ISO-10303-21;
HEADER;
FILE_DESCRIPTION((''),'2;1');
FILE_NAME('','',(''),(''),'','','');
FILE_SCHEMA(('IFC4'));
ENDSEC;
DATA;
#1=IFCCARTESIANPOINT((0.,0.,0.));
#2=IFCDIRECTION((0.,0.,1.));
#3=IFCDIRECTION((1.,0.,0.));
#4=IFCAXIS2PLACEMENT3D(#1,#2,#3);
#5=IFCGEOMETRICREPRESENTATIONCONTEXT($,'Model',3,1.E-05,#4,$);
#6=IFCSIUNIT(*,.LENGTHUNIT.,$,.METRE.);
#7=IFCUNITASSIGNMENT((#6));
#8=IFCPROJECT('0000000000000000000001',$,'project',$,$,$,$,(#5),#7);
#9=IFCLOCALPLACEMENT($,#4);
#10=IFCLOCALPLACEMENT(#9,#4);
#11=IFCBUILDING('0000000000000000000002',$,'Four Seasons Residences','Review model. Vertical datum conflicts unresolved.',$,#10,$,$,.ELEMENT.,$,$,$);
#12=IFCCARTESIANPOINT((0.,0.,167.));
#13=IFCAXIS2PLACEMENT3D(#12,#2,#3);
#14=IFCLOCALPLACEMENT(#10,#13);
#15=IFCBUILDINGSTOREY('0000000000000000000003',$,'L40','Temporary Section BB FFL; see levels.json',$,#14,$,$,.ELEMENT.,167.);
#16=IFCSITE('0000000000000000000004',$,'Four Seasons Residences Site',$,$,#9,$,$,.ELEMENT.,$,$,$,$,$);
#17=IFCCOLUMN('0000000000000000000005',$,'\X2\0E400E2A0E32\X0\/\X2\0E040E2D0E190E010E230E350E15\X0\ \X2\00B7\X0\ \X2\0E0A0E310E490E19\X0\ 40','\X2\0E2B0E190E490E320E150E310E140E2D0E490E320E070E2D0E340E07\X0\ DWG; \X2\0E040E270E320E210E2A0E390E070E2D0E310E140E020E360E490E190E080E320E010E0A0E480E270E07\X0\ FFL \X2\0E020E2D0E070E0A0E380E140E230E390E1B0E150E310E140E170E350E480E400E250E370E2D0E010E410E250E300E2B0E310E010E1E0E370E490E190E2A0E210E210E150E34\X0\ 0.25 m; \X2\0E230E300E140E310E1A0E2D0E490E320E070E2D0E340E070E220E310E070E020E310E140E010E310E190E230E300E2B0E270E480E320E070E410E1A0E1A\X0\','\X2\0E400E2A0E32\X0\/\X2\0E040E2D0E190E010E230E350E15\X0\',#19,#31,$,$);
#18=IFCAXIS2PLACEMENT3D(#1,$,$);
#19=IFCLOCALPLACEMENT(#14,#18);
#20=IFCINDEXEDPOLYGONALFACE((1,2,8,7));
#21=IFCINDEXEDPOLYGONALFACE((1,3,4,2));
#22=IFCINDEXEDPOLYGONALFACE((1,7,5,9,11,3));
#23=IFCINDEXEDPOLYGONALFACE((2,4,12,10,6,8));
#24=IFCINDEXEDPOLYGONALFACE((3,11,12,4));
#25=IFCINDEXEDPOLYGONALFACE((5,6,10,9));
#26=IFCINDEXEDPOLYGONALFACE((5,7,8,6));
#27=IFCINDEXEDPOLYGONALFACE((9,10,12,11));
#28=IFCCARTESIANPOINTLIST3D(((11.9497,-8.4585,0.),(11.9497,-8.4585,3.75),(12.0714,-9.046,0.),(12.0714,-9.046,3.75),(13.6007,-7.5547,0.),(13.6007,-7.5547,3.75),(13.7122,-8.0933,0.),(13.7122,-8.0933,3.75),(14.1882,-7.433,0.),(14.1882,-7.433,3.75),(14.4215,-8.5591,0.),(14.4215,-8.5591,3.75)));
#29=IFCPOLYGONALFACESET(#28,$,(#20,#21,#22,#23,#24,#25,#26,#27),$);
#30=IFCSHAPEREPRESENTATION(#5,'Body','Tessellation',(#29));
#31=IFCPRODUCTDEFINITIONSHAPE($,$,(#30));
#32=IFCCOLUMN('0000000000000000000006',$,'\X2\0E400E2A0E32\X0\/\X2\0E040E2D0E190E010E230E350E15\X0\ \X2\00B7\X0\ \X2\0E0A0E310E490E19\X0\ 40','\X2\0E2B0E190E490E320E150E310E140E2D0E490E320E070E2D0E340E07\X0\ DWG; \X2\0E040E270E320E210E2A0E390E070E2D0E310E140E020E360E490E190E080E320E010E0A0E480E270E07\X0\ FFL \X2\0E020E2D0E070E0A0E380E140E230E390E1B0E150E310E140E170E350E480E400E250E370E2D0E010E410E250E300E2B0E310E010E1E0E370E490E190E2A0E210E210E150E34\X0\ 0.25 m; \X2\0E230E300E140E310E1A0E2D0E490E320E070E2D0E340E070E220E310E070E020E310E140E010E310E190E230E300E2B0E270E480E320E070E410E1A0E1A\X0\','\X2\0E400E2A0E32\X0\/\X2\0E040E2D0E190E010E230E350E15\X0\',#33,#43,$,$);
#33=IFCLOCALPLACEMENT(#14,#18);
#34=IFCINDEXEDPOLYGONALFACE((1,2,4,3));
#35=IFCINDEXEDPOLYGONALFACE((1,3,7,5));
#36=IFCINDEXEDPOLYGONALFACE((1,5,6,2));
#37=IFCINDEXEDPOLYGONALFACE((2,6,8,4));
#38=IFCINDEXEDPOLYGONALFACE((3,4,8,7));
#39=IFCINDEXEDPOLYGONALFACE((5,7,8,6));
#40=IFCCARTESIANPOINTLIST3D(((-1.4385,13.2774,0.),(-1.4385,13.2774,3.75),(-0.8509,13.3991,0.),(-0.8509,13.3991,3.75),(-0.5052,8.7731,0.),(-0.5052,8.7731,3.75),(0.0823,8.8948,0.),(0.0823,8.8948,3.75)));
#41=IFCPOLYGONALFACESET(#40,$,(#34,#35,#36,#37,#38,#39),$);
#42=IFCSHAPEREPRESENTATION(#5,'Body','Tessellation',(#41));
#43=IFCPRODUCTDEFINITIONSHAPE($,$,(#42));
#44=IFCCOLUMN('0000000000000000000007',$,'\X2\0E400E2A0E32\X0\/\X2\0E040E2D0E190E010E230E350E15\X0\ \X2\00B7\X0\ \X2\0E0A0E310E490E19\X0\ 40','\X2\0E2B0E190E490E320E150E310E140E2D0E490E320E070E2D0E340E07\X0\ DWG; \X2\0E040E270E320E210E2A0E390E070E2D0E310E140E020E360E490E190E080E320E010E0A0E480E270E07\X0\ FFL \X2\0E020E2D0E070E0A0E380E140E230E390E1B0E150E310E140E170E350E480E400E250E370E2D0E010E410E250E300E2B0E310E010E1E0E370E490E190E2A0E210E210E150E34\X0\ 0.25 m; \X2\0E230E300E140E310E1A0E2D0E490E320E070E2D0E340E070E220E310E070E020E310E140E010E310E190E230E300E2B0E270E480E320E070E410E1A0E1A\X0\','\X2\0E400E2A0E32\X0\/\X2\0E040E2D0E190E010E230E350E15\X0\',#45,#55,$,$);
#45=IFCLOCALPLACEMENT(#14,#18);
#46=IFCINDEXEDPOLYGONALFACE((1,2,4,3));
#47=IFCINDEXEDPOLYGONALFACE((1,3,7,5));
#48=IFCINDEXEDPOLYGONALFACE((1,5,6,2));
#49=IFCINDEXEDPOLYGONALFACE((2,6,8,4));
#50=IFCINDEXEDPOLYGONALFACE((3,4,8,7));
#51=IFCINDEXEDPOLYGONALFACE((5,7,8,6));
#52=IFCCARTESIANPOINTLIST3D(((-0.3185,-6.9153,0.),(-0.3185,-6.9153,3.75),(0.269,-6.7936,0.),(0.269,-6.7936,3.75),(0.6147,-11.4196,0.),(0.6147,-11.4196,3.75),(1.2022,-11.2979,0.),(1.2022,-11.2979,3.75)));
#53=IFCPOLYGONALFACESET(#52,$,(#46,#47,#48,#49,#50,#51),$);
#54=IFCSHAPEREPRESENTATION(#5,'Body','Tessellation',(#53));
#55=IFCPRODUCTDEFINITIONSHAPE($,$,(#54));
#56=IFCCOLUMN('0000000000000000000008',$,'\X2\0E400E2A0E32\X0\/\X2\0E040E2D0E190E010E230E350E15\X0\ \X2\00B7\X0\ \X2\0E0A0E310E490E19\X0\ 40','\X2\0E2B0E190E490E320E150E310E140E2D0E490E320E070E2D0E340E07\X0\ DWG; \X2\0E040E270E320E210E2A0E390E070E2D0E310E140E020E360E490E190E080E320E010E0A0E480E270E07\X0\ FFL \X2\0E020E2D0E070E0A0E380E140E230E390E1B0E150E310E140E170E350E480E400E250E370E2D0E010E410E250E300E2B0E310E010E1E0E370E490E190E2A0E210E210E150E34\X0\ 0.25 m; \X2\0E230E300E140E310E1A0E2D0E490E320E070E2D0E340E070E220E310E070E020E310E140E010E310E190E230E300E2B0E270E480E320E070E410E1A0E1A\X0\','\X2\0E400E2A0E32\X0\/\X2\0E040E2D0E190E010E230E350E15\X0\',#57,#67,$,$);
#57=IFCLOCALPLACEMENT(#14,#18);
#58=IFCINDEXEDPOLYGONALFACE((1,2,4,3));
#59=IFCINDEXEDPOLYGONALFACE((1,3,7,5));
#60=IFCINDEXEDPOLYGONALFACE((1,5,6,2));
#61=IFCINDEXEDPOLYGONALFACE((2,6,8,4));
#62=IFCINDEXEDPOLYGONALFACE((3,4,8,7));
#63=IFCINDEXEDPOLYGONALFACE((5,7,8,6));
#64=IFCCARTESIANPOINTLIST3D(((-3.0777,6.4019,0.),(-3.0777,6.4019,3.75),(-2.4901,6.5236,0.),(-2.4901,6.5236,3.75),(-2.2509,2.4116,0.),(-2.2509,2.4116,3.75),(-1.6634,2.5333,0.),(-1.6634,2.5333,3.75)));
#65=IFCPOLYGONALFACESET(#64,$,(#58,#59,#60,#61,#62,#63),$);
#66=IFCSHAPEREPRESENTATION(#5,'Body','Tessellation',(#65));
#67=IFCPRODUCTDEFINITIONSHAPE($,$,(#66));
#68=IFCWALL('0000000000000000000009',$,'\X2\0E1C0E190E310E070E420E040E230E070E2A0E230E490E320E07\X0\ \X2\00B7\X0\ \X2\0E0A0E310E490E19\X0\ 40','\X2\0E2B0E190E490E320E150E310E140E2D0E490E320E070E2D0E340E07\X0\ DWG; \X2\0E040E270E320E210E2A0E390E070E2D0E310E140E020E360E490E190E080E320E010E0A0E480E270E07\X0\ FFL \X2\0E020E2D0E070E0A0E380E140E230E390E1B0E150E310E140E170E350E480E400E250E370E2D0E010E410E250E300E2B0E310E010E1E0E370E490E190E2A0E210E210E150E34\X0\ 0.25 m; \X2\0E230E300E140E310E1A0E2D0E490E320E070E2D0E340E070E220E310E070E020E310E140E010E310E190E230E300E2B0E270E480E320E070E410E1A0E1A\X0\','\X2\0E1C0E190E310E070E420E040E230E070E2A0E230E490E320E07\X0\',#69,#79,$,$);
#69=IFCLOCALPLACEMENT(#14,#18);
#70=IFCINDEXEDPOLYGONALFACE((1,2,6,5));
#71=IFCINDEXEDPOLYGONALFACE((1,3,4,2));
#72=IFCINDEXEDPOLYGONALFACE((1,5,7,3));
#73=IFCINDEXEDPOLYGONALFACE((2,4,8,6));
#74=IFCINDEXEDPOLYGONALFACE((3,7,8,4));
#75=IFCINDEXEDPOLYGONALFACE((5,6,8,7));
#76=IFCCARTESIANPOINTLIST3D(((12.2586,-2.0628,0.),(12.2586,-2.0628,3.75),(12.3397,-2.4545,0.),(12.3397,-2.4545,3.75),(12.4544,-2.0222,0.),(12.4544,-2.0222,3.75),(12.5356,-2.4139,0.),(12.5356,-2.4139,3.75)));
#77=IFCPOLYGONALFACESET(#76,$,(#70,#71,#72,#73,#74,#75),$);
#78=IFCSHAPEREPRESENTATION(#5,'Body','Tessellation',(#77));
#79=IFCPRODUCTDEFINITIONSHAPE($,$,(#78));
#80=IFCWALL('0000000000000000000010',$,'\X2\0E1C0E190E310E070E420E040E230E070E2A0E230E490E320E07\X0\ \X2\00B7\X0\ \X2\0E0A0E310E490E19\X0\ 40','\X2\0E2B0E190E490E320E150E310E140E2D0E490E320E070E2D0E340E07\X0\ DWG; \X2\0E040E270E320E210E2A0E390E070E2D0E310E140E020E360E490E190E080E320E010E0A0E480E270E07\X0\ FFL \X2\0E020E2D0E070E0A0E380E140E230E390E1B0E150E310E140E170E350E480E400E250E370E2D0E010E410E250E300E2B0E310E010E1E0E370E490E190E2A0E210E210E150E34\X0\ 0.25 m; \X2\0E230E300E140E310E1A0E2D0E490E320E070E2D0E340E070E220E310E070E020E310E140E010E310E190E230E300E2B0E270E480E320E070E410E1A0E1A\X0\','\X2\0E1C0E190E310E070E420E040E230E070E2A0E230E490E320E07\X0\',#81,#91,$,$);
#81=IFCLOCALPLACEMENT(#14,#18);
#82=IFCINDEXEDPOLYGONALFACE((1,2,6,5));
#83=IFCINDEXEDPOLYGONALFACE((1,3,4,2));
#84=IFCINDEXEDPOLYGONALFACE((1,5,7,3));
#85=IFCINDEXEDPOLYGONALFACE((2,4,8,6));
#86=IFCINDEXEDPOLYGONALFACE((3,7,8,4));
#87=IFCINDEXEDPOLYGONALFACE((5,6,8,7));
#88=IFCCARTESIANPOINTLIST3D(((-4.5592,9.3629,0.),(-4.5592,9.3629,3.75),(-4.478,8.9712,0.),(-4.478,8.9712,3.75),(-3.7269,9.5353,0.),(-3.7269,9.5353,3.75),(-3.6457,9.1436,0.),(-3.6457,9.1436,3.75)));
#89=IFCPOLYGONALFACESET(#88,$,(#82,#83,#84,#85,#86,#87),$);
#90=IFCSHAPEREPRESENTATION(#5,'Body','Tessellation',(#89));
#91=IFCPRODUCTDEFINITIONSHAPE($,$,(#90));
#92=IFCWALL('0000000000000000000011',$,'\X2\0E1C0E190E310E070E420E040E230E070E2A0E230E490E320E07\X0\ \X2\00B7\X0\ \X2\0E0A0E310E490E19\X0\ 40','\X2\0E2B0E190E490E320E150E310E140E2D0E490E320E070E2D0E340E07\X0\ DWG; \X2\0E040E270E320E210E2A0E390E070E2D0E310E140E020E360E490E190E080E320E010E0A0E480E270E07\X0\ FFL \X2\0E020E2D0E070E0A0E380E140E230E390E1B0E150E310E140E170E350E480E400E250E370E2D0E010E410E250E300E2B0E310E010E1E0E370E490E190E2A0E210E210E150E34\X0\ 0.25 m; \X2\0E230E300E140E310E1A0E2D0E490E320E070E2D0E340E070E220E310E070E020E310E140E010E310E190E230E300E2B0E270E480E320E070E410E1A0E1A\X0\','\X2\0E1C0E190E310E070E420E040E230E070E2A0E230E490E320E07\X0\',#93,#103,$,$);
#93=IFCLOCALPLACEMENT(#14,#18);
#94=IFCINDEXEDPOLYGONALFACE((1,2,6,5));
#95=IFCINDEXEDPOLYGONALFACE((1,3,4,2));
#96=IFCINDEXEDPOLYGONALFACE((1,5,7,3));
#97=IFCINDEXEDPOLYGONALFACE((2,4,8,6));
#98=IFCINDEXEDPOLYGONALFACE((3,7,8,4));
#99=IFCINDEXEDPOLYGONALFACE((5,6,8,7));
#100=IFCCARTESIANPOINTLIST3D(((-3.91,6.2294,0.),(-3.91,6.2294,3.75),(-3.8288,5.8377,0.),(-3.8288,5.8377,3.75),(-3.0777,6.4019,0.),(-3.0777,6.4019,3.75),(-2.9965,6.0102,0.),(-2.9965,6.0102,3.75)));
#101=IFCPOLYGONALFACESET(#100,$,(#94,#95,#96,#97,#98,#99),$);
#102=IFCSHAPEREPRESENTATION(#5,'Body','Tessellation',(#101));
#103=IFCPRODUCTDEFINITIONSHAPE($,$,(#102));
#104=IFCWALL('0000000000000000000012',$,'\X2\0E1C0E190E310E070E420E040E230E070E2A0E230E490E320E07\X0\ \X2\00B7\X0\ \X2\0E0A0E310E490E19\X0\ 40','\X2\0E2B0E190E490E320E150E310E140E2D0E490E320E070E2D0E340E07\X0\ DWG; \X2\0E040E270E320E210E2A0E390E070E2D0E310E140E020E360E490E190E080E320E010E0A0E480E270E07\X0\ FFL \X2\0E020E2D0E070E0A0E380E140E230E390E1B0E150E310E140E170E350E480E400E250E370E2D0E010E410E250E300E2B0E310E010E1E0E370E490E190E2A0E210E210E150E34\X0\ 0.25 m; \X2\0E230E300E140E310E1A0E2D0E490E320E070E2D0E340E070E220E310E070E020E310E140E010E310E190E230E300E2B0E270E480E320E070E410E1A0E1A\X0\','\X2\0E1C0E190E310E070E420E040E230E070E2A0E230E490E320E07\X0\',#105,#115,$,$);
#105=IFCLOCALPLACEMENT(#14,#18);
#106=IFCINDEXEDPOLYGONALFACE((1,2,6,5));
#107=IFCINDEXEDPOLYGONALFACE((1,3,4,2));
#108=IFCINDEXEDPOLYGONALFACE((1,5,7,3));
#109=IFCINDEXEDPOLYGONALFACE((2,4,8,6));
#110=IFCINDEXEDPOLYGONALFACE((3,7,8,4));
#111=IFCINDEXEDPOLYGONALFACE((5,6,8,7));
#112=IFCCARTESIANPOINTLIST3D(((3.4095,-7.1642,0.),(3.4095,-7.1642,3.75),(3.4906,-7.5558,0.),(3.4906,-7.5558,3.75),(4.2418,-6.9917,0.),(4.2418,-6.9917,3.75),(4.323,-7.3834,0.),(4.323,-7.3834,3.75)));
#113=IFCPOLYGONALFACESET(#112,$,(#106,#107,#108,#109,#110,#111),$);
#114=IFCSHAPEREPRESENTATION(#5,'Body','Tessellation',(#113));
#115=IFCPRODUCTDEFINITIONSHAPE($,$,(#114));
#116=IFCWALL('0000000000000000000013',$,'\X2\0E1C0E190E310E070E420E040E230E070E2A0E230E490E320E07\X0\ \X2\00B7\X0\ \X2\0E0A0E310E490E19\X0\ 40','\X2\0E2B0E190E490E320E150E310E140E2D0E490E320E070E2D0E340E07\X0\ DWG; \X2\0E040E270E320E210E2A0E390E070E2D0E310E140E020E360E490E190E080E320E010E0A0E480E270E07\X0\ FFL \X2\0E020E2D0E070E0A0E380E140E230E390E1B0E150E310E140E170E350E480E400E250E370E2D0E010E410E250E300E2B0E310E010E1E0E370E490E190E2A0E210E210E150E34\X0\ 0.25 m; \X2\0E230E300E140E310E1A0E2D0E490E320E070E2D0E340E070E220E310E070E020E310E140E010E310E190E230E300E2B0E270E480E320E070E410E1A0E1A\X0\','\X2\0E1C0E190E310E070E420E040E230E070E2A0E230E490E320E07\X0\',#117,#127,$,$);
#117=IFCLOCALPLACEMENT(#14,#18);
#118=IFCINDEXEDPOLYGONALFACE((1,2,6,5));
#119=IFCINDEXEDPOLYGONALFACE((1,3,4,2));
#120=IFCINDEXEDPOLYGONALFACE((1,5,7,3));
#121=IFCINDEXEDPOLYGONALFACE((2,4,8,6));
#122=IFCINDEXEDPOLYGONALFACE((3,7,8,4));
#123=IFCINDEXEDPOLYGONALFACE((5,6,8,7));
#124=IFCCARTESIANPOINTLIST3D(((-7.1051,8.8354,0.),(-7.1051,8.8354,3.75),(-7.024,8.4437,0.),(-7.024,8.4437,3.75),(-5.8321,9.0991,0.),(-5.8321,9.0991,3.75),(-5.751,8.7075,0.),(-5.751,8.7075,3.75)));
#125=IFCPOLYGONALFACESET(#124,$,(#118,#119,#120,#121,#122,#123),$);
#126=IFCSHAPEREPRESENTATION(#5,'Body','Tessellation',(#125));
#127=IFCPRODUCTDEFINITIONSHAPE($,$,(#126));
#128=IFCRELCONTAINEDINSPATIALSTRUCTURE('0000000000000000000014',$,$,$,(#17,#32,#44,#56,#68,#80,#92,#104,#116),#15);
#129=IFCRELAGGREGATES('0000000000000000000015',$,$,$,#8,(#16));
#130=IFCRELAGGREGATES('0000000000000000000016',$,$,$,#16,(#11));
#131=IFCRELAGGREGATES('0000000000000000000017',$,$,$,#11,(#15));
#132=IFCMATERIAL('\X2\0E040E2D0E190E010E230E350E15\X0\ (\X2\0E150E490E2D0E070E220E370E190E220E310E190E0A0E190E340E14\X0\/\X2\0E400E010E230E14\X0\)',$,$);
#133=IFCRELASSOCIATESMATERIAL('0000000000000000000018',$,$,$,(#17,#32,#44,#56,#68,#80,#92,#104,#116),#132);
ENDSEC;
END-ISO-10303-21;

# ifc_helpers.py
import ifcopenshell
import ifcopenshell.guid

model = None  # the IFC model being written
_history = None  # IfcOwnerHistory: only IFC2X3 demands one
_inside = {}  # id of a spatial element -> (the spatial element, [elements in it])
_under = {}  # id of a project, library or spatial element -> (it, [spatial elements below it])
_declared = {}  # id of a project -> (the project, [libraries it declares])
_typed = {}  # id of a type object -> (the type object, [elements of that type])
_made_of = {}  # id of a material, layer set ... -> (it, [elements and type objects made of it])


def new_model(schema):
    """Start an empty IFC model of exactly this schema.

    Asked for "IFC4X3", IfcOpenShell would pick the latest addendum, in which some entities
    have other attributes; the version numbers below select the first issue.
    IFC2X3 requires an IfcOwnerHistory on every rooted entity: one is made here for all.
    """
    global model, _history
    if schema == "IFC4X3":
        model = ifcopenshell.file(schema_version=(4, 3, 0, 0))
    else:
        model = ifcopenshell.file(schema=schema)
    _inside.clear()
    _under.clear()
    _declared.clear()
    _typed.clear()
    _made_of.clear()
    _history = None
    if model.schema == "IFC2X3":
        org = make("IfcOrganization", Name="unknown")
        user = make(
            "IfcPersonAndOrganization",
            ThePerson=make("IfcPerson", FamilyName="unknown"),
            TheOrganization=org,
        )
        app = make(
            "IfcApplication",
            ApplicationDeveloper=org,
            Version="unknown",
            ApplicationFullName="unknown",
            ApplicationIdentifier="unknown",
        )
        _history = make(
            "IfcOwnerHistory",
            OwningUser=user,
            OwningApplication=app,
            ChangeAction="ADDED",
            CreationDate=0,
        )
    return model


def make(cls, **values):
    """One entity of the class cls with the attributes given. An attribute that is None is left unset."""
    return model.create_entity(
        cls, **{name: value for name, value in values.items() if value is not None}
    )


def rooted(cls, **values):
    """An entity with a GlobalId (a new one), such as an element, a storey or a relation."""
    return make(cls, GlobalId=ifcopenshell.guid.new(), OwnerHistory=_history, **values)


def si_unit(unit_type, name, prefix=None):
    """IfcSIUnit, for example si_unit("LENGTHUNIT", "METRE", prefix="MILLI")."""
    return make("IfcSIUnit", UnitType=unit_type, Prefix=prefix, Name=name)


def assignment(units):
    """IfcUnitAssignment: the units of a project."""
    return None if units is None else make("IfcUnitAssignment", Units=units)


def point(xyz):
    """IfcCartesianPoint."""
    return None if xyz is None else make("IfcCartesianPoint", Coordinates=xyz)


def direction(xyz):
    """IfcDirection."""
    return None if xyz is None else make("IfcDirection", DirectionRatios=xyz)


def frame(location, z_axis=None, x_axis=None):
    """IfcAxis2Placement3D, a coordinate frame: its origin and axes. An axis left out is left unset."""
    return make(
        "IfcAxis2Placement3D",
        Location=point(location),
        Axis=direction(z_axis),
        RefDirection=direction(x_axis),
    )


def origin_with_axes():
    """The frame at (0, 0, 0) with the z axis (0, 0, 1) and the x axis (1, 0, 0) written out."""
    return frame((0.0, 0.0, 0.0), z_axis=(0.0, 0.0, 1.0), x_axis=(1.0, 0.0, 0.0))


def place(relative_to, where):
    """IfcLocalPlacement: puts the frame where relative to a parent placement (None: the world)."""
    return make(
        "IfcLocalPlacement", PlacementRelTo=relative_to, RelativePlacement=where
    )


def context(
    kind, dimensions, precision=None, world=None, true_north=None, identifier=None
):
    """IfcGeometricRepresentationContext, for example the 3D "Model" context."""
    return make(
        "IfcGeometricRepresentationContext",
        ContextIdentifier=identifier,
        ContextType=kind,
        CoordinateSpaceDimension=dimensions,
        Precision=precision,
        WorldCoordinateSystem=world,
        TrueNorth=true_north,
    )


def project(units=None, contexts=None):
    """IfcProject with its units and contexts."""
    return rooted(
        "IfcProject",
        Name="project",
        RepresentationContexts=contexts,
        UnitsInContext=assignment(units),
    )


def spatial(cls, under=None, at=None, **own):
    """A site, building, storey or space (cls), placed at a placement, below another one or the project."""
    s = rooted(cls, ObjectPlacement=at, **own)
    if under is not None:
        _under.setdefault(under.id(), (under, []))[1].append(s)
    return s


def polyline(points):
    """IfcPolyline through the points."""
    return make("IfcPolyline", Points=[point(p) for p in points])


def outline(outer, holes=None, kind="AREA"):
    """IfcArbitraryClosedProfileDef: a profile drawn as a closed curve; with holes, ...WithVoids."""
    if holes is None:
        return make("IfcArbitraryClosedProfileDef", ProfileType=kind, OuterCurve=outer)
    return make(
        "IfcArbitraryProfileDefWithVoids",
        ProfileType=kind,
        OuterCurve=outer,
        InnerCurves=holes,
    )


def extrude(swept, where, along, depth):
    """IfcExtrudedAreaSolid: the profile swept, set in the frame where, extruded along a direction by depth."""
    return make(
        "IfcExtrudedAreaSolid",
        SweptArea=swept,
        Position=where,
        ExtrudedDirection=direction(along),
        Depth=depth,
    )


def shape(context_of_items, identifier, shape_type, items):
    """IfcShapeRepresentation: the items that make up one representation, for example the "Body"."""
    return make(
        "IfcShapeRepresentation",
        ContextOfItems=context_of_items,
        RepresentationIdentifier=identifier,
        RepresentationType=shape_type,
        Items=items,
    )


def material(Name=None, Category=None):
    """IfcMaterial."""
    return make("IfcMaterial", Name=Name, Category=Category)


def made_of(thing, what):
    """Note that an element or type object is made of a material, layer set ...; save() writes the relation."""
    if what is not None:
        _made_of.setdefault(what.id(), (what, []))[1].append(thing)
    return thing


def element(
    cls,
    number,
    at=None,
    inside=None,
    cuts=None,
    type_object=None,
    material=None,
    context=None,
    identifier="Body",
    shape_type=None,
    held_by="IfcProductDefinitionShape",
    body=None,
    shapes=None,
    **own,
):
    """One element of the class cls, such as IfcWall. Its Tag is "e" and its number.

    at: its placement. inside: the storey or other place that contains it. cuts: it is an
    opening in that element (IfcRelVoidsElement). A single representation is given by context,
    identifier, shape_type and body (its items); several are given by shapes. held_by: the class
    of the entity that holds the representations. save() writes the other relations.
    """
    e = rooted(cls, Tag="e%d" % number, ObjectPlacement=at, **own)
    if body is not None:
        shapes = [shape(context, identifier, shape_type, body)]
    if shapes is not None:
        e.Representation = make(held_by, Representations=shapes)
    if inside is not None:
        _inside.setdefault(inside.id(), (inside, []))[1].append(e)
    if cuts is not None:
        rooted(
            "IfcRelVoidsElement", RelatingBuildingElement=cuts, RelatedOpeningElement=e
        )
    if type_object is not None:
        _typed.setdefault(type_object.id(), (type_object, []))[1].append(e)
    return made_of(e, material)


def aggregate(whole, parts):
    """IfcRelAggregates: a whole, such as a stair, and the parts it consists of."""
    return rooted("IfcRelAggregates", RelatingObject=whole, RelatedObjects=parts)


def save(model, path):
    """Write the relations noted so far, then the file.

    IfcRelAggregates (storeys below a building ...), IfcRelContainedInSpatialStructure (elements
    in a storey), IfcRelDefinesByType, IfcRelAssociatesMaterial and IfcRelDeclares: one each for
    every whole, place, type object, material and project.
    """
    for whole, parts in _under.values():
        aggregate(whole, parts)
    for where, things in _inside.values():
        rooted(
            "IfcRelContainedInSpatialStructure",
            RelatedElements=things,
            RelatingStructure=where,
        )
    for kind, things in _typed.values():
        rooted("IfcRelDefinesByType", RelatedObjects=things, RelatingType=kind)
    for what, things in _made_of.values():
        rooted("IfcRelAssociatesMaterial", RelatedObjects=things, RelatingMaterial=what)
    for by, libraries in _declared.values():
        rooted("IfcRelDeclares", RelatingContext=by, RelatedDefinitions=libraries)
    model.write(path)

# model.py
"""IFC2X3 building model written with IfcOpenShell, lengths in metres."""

from ifc_helpers import new_model, si_unit, frame, origin_with_axes, place, context, project, spatial, polyline, outline, extrude, material, element, save


model = new_model("IFC2X3")

# Units and contexts
model_context = context("Model", 3, precision=1e-05, world=origin_with_axes())
ifc_project = project(units=[si_unit("LENGTHUNIT", "METRE")], contexts=[model_context])

# Site, building, storey
site_placement = place(None, origin_with_axes())
site = spatial("IfcSite", under=ifc_project, at=site_placement, Name="Four Seasons Residences Site", CompositionType="ELEMENT")
building_placement = place(site_placement, origin_with_axes())
building = spatial("IfcBuilding", under=site, at=building_placement, Name="Four Seasons Residences", Description="Review model. Vertical datum conflicts unresolved.", CompositionType="ELEMENT")
storey_placement = place(building_placement, frame((0.0, 0.0, 167.0), z_axis=(0.0, 0.0, 1.0), x_axis=(1.0, 0.0, 0.0)))
storey = spatial("IfcBuildingStorey", under=building, at=storey_placement, Name="L40", Description="Temporary Section BB FFL; see levels.json", CompositionType="ELEMENT", Elevation=167.0)

# Columns
ifc_material = material(Name="คอนกรีต (ต้องยืนยันชนิด/เกรด)")
column_1_placement = place(storey_placement, origin_with_axes())
element("IfcColumn", 1, at=column_1_placement, inside=storey, material=ifc_material, Name="เสา/คอนกรีต · ชั้น 40", Description="หน้าตัดอ้างอิง DWG; ความสูงอัดขึ้นจากช่วง FFL ของชุดรูปตัดที่เลือกและหักพื้นสมมติ 0.25 m; ระดับอ้างอิงยังขัดกันระหว่างแบบ", ObjectType="เสา/คอนกรีต", context=model_context, shape_type="SweptSolid", body=[
    extrude(outline(polyline([(12.0714, -9.046), (14.4215, -8.5591), (14.1882, -7.433), (13.6007, -7.5547), (13.7122, -8.0933), (11.9497, -8.4585), (12.0714, -9.046)])), origin_with_axes(), (0.0, 0.0, 1.0), 3.75),
])
column_2_placement = place(storey_placement, origin_with_axes())
element("IfcColumn", 2, at=column_2_placement, inside=storey, material=ifc_material, Name="เสา/คอนกรีต · ชั้น 40", Description="หน้าตัดอ้างอิง DWG; ความสูงอัดขึ้นจากช่วง FFL ของชุดรูปตัดที่เลือกและหักพื้นสมมติ 0.25 m; ระดับอ้างอิงยังขัดกันระหว่างแบบ", ObjectType="เสา/คอนกรีต", context=model_context, shape_type="SweptSolid", body=[
    extrude(outline(polyline([(-0.8509, 13.3991), (0.0823, 8.8948), (-0.5052, 8.7731), (-1.4385, 13.2774), (-0.8509, 13.3991)])), origin_with_axes(), (0.0, 0.0, 1.0), 3.75),
])
column_3_placement = place(storey_placement, origin_with_axes())
element("IfcColumn", 3, at=column_3_placement, inside=storey, material=ifc_material, Name="เสา/คอนกรีต · ชั้น 40", Description="หน้าตัดอ้างอิง DWG; ความสูงอัดขึ้นจากช่วง FFL ของชุดรูปตัดที่เลือกและหักพื้นสมมติ 0.25 m; ระดับอ้างอิงยังขัดกันระหว่างแบบ", ObjectType="เสา/คอนกรีต", context=model_context, shape_type="SweptSolid", body=[
    extrude(outline(polyline([(0.269, -6.7936), (1.2022, -11.2979), (0.6147, -11.4196), (-0.3185, -6.9153), (0.269, -6.7936)])), origin_with_axes(), (0.0, 0.0, 1.0), 3.75),
])
column_4_placement = place(storey_placement, origin_with_axes())
element("IfcColumn", 4, at=column_4_placement, inside=storey, material=ifc_material, Name="เสา/คอนกรีต · ชั้น 40", Description="หน้าตัดอ้างอิง DWG; ความสูงอัดขึ้นจากช่วง FFL ของชุดรูปตัดที่เลือกและหักพื้นสมมติ 0.25 m; ระดับอ้างอิงยังขัดกันระหว่างแบบ", ObjectType="เสา/คอนกรีต", context=model_context, shape_type="SweptSolid", body=[
    extrude(outline(polyline([(-2.4901, 6.5236), (-1.6634, 2.5333), (-2.2509, 2.4116), (-3.0777, 6.4019), (-2.4901, 6.5236)])), origin_with_axes(), (0.0, 0.0, 1.0), 3.75),
])

# Walls
wall_1_placement = place(storey_placement, origin_with_axes())
element("IfcWall", 5, at=wall_1_placement, inside=storey, material=ifc_material, Name="ผนังโครงสร้าง · ชั้น 40", Description="หน้าตัดอ้างอิง DWG; ความสูงอัดขึ้นจากช่วง FFL ของชุดรูปตัดที่เลือกและหักพื้นสมมติ 0.25 m; ระดับอ้างอิงยังขัดกันระหว่างแบบ", ObjectType="ผนังโครงสร้าง", context=model_context, shape_type="SweptSolid", body=[
    extrude(outline(polyline([(12.2586, -2.0628), (12.3397, -2.4545), (12.5356, -2.4139), (12.4544, -2.0222), (12.2586, -2.0628)])), origin_with_axes(), (0.0, 0.0, 1.0), 3.75),
])
wall_2_placement = place(storey_placement, origin_with_axes())
element("IfcWall", 6, at=wall_2_placement, inside=storey, material=ifc_material, Name="ผนังโครงสร้าง · ชั้น 40", Description="หน้าตัดอ้างอิง DWG; ความสูงอัดขึ้นจากช่วง FFL ของชุดรูปตัดที่เลือกและหักพื้นสมมติ 0.25 m; ระดับอ้างอิงยังขัดกันระหว่างแบบ", ObjectType="ผนังโครงสร้าง", context=model_context, shape_type="SweptSolid", body=[
    extrude(outline(polyline([(-4.5592, 9.3629), (-4.478, 8.9712), (-3.6457, 9.1436), (-3.7269, 9.5353), (-4.5592, 9.3629)])), origin_with_axes(), (0.0, 0.0, 1.0), 3.75),
])
wall_3_placement = place(storey_placement, origin_with_axes())
element("IfcWall", 7, at=wall_3_placement, inside=storey, material=ifc_material, Name="ผนังโครงสร้าง · ชั้น 40", Description="หน้าตัดอ้างอิง DWG; ความสูงอัดขึ้นจากช่วง FFL ของชุดรูปตัดที่เลือกและหักพื้นสมมติ 0.25 m; ระดับอ้างอิงยังขัดกันระหว่างแบบ", ObjectType="ผนังโครงสร้าง", context=model_context, shape_type="SweptSolid", body=[
    extrude(outline(polyline([(-3.0777, 6.4019), (-2.9965, 6.0102), (-3.8288, 5.8377), (-3.91, 6.2294), (-3.0777, 6.4019)])), origin_with_axes(), (0.0, 0.0, 1.0), 3.75),
])
wall_4_placement = place(storey_placement, origin_with_axes())
element("IfcWall", 8, at=wall_4_placement, inside=storey, material=ifc_material, Name="ผนังโครงสร้าง · ชั้น 40", Description="หน้าตัดอ้างอิง DWG; ความสูงอัดขึ้นจากช่วง FFL ของชุดรูปตัดที่เลือกและหักพื้นสมมติ 0.25 m; ระดับอ้างอิงยังขัดกันระหว่างแบบ", ObjectType="ผนังโครงสร้าง", context=model_context, shape_type="SweptSolid", body=[
    extrude(outline(polyline([(4.323, -7.3834), (4.2418, -6.9917), (3.4095, -7.1642), (3.4906, -7.5558), (4.323, -7.3834)])), origin_with_axes(), (0.0, 0.0, 1.0), 3.75),
])
wall_5_placement = place(storey_placement, origin_with_axes())
element("IfcWall", 9, at=wall_5_placement, inside=storey, material=ifc_material, Name="ผนังโครงสร้าง · ชั้น 40", Description="หน้าตัดอ้างอิง DWG; ความสูงอัดขึ้นจากช่วง FFL ของชุดรูปตัดที่เลือกและหักพื้นสมมติ 0.25 m; ระดับอ้างอิงยังขัดกันระหว่างแบบ", ObjectType="ผนังโครงสร้าง", context=model_context, shape_type="SweptSolid", body=[
    extrude(outline(polyline([(-5.751, 8.7075), (-5.8321, 9.0991), (-7.1051, 8.8354), (-7.024, 8.4437), (-5.751, 8.7075)])), origin_with_axes(), (0.0, 0.0, 1.0), 3.75),
])

save(model, "model.ifc")
